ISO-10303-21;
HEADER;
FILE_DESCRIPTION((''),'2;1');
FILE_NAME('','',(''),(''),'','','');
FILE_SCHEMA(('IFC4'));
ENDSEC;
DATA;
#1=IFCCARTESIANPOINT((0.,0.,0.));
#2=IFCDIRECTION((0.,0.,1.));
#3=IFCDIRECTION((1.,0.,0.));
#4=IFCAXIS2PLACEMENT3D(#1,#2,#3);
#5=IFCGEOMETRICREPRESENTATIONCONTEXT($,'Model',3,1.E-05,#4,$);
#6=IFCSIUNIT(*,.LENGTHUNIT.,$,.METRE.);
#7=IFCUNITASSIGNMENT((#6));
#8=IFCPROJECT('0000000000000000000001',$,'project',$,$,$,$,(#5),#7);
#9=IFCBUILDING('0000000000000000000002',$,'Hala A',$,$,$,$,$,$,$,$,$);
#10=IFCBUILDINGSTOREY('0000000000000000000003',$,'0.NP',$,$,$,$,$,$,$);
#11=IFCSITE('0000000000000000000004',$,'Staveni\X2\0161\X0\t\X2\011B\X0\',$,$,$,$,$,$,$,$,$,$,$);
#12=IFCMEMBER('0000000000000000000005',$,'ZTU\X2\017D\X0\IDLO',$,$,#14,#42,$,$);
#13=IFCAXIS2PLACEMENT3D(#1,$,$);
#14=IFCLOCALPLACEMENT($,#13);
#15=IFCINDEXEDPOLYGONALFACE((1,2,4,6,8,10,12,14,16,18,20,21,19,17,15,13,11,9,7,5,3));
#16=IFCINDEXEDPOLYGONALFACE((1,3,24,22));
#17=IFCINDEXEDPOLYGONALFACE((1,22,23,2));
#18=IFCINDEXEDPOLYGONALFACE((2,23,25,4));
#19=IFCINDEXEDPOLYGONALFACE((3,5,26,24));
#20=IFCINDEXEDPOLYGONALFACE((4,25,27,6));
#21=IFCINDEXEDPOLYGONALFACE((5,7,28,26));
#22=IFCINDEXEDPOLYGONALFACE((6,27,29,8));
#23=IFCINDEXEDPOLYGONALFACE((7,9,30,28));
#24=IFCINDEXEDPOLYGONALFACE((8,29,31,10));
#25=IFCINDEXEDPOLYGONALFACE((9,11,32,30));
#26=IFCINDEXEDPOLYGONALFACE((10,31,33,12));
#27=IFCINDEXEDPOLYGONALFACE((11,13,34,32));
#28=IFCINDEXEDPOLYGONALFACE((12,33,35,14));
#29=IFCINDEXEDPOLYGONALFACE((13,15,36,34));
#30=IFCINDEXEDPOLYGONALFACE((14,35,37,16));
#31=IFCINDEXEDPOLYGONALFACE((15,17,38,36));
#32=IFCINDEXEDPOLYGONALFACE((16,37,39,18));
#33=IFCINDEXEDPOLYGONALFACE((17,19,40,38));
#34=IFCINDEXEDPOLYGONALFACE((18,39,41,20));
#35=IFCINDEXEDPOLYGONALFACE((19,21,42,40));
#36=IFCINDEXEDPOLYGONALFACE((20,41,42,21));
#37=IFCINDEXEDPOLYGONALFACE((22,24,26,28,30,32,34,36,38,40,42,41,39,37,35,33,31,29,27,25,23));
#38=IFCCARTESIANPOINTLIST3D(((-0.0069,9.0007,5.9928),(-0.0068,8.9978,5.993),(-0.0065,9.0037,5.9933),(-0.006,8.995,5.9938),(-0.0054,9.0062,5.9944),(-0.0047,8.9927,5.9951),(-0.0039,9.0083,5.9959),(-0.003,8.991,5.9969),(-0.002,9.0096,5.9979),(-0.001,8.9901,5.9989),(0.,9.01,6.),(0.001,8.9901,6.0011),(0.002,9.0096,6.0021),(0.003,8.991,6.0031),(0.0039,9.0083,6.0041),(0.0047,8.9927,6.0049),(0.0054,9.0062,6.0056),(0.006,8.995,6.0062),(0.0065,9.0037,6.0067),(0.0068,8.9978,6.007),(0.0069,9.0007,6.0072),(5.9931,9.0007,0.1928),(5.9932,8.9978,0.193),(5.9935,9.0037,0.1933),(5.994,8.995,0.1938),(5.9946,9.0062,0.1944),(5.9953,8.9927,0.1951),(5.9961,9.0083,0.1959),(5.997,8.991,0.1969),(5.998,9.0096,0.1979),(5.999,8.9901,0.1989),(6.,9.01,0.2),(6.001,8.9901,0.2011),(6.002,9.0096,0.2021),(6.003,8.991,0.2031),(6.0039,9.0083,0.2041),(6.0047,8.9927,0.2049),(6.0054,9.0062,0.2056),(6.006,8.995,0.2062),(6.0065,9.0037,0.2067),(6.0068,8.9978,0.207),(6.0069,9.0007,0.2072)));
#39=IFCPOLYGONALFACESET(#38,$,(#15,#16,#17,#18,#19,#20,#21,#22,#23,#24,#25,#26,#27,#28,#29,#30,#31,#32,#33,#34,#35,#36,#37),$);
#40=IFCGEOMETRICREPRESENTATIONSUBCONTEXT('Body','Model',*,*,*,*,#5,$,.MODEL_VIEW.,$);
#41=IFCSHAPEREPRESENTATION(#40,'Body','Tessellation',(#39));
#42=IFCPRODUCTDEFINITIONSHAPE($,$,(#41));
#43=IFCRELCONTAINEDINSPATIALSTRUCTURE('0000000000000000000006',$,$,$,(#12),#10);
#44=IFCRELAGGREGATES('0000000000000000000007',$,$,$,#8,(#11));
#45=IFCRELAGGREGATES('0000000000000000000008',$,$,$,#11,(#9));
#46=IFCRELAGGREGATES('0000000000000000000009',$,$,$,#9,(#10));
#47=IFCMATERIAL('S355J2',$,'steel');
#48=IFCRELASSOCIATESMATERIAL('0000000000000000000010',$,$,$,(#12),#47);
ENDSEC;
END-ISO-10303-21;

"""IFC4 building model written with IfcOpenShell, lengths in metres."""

from ifc_helpers import new_model, si_unit, frame, origin_with_axes, place, context, subcontext, project, spatial, circle, extrude, material, element, save


model = new_model("IFC4")

# Units and contexts
model_context = context("Model", 3, precision=1e-05, world=origin_with_axes())
body_context = subcontext(model_context, "Body", "Model", "MODEL_VIEW")
ifc_project = project(units=[si_unit("LENGTHUNIT", "METRE")], contexts=[model_context])

# Site, building, storey
site = spatial("IfcSite", under=ifc_project, Name="Staveniště")
building = spatial("IfcBuilding", under=site, Name="Hala A")
storey = spatial("IfcBuildingStorey", under=building, Name="0.NP")

# Shared definitions
ifc_material = material(Name="S355J2", Category="steel")

# Member
for number, where, z_axis, x_axis, name in (
    (1, (0.0, 9.0, 6.0), (0.718988, 0.0, -0.695022), (0.0, 1.0, 0.0), "ZTUŽIDLO"),
):
    element("IfcMember", number, at=place(None, frame(where, z_axis=z_axis, x_axis=x_axis)), inside=storey, material=ifc_material, Name=name, context=body_context, shape_type="SweptSolid", body=[
        extrude(circle(Radius=0.01), origin_with_axes(), (0.0, 0.0, 1.0), 8.3451),
    ])

save(model, "model.ifc")
